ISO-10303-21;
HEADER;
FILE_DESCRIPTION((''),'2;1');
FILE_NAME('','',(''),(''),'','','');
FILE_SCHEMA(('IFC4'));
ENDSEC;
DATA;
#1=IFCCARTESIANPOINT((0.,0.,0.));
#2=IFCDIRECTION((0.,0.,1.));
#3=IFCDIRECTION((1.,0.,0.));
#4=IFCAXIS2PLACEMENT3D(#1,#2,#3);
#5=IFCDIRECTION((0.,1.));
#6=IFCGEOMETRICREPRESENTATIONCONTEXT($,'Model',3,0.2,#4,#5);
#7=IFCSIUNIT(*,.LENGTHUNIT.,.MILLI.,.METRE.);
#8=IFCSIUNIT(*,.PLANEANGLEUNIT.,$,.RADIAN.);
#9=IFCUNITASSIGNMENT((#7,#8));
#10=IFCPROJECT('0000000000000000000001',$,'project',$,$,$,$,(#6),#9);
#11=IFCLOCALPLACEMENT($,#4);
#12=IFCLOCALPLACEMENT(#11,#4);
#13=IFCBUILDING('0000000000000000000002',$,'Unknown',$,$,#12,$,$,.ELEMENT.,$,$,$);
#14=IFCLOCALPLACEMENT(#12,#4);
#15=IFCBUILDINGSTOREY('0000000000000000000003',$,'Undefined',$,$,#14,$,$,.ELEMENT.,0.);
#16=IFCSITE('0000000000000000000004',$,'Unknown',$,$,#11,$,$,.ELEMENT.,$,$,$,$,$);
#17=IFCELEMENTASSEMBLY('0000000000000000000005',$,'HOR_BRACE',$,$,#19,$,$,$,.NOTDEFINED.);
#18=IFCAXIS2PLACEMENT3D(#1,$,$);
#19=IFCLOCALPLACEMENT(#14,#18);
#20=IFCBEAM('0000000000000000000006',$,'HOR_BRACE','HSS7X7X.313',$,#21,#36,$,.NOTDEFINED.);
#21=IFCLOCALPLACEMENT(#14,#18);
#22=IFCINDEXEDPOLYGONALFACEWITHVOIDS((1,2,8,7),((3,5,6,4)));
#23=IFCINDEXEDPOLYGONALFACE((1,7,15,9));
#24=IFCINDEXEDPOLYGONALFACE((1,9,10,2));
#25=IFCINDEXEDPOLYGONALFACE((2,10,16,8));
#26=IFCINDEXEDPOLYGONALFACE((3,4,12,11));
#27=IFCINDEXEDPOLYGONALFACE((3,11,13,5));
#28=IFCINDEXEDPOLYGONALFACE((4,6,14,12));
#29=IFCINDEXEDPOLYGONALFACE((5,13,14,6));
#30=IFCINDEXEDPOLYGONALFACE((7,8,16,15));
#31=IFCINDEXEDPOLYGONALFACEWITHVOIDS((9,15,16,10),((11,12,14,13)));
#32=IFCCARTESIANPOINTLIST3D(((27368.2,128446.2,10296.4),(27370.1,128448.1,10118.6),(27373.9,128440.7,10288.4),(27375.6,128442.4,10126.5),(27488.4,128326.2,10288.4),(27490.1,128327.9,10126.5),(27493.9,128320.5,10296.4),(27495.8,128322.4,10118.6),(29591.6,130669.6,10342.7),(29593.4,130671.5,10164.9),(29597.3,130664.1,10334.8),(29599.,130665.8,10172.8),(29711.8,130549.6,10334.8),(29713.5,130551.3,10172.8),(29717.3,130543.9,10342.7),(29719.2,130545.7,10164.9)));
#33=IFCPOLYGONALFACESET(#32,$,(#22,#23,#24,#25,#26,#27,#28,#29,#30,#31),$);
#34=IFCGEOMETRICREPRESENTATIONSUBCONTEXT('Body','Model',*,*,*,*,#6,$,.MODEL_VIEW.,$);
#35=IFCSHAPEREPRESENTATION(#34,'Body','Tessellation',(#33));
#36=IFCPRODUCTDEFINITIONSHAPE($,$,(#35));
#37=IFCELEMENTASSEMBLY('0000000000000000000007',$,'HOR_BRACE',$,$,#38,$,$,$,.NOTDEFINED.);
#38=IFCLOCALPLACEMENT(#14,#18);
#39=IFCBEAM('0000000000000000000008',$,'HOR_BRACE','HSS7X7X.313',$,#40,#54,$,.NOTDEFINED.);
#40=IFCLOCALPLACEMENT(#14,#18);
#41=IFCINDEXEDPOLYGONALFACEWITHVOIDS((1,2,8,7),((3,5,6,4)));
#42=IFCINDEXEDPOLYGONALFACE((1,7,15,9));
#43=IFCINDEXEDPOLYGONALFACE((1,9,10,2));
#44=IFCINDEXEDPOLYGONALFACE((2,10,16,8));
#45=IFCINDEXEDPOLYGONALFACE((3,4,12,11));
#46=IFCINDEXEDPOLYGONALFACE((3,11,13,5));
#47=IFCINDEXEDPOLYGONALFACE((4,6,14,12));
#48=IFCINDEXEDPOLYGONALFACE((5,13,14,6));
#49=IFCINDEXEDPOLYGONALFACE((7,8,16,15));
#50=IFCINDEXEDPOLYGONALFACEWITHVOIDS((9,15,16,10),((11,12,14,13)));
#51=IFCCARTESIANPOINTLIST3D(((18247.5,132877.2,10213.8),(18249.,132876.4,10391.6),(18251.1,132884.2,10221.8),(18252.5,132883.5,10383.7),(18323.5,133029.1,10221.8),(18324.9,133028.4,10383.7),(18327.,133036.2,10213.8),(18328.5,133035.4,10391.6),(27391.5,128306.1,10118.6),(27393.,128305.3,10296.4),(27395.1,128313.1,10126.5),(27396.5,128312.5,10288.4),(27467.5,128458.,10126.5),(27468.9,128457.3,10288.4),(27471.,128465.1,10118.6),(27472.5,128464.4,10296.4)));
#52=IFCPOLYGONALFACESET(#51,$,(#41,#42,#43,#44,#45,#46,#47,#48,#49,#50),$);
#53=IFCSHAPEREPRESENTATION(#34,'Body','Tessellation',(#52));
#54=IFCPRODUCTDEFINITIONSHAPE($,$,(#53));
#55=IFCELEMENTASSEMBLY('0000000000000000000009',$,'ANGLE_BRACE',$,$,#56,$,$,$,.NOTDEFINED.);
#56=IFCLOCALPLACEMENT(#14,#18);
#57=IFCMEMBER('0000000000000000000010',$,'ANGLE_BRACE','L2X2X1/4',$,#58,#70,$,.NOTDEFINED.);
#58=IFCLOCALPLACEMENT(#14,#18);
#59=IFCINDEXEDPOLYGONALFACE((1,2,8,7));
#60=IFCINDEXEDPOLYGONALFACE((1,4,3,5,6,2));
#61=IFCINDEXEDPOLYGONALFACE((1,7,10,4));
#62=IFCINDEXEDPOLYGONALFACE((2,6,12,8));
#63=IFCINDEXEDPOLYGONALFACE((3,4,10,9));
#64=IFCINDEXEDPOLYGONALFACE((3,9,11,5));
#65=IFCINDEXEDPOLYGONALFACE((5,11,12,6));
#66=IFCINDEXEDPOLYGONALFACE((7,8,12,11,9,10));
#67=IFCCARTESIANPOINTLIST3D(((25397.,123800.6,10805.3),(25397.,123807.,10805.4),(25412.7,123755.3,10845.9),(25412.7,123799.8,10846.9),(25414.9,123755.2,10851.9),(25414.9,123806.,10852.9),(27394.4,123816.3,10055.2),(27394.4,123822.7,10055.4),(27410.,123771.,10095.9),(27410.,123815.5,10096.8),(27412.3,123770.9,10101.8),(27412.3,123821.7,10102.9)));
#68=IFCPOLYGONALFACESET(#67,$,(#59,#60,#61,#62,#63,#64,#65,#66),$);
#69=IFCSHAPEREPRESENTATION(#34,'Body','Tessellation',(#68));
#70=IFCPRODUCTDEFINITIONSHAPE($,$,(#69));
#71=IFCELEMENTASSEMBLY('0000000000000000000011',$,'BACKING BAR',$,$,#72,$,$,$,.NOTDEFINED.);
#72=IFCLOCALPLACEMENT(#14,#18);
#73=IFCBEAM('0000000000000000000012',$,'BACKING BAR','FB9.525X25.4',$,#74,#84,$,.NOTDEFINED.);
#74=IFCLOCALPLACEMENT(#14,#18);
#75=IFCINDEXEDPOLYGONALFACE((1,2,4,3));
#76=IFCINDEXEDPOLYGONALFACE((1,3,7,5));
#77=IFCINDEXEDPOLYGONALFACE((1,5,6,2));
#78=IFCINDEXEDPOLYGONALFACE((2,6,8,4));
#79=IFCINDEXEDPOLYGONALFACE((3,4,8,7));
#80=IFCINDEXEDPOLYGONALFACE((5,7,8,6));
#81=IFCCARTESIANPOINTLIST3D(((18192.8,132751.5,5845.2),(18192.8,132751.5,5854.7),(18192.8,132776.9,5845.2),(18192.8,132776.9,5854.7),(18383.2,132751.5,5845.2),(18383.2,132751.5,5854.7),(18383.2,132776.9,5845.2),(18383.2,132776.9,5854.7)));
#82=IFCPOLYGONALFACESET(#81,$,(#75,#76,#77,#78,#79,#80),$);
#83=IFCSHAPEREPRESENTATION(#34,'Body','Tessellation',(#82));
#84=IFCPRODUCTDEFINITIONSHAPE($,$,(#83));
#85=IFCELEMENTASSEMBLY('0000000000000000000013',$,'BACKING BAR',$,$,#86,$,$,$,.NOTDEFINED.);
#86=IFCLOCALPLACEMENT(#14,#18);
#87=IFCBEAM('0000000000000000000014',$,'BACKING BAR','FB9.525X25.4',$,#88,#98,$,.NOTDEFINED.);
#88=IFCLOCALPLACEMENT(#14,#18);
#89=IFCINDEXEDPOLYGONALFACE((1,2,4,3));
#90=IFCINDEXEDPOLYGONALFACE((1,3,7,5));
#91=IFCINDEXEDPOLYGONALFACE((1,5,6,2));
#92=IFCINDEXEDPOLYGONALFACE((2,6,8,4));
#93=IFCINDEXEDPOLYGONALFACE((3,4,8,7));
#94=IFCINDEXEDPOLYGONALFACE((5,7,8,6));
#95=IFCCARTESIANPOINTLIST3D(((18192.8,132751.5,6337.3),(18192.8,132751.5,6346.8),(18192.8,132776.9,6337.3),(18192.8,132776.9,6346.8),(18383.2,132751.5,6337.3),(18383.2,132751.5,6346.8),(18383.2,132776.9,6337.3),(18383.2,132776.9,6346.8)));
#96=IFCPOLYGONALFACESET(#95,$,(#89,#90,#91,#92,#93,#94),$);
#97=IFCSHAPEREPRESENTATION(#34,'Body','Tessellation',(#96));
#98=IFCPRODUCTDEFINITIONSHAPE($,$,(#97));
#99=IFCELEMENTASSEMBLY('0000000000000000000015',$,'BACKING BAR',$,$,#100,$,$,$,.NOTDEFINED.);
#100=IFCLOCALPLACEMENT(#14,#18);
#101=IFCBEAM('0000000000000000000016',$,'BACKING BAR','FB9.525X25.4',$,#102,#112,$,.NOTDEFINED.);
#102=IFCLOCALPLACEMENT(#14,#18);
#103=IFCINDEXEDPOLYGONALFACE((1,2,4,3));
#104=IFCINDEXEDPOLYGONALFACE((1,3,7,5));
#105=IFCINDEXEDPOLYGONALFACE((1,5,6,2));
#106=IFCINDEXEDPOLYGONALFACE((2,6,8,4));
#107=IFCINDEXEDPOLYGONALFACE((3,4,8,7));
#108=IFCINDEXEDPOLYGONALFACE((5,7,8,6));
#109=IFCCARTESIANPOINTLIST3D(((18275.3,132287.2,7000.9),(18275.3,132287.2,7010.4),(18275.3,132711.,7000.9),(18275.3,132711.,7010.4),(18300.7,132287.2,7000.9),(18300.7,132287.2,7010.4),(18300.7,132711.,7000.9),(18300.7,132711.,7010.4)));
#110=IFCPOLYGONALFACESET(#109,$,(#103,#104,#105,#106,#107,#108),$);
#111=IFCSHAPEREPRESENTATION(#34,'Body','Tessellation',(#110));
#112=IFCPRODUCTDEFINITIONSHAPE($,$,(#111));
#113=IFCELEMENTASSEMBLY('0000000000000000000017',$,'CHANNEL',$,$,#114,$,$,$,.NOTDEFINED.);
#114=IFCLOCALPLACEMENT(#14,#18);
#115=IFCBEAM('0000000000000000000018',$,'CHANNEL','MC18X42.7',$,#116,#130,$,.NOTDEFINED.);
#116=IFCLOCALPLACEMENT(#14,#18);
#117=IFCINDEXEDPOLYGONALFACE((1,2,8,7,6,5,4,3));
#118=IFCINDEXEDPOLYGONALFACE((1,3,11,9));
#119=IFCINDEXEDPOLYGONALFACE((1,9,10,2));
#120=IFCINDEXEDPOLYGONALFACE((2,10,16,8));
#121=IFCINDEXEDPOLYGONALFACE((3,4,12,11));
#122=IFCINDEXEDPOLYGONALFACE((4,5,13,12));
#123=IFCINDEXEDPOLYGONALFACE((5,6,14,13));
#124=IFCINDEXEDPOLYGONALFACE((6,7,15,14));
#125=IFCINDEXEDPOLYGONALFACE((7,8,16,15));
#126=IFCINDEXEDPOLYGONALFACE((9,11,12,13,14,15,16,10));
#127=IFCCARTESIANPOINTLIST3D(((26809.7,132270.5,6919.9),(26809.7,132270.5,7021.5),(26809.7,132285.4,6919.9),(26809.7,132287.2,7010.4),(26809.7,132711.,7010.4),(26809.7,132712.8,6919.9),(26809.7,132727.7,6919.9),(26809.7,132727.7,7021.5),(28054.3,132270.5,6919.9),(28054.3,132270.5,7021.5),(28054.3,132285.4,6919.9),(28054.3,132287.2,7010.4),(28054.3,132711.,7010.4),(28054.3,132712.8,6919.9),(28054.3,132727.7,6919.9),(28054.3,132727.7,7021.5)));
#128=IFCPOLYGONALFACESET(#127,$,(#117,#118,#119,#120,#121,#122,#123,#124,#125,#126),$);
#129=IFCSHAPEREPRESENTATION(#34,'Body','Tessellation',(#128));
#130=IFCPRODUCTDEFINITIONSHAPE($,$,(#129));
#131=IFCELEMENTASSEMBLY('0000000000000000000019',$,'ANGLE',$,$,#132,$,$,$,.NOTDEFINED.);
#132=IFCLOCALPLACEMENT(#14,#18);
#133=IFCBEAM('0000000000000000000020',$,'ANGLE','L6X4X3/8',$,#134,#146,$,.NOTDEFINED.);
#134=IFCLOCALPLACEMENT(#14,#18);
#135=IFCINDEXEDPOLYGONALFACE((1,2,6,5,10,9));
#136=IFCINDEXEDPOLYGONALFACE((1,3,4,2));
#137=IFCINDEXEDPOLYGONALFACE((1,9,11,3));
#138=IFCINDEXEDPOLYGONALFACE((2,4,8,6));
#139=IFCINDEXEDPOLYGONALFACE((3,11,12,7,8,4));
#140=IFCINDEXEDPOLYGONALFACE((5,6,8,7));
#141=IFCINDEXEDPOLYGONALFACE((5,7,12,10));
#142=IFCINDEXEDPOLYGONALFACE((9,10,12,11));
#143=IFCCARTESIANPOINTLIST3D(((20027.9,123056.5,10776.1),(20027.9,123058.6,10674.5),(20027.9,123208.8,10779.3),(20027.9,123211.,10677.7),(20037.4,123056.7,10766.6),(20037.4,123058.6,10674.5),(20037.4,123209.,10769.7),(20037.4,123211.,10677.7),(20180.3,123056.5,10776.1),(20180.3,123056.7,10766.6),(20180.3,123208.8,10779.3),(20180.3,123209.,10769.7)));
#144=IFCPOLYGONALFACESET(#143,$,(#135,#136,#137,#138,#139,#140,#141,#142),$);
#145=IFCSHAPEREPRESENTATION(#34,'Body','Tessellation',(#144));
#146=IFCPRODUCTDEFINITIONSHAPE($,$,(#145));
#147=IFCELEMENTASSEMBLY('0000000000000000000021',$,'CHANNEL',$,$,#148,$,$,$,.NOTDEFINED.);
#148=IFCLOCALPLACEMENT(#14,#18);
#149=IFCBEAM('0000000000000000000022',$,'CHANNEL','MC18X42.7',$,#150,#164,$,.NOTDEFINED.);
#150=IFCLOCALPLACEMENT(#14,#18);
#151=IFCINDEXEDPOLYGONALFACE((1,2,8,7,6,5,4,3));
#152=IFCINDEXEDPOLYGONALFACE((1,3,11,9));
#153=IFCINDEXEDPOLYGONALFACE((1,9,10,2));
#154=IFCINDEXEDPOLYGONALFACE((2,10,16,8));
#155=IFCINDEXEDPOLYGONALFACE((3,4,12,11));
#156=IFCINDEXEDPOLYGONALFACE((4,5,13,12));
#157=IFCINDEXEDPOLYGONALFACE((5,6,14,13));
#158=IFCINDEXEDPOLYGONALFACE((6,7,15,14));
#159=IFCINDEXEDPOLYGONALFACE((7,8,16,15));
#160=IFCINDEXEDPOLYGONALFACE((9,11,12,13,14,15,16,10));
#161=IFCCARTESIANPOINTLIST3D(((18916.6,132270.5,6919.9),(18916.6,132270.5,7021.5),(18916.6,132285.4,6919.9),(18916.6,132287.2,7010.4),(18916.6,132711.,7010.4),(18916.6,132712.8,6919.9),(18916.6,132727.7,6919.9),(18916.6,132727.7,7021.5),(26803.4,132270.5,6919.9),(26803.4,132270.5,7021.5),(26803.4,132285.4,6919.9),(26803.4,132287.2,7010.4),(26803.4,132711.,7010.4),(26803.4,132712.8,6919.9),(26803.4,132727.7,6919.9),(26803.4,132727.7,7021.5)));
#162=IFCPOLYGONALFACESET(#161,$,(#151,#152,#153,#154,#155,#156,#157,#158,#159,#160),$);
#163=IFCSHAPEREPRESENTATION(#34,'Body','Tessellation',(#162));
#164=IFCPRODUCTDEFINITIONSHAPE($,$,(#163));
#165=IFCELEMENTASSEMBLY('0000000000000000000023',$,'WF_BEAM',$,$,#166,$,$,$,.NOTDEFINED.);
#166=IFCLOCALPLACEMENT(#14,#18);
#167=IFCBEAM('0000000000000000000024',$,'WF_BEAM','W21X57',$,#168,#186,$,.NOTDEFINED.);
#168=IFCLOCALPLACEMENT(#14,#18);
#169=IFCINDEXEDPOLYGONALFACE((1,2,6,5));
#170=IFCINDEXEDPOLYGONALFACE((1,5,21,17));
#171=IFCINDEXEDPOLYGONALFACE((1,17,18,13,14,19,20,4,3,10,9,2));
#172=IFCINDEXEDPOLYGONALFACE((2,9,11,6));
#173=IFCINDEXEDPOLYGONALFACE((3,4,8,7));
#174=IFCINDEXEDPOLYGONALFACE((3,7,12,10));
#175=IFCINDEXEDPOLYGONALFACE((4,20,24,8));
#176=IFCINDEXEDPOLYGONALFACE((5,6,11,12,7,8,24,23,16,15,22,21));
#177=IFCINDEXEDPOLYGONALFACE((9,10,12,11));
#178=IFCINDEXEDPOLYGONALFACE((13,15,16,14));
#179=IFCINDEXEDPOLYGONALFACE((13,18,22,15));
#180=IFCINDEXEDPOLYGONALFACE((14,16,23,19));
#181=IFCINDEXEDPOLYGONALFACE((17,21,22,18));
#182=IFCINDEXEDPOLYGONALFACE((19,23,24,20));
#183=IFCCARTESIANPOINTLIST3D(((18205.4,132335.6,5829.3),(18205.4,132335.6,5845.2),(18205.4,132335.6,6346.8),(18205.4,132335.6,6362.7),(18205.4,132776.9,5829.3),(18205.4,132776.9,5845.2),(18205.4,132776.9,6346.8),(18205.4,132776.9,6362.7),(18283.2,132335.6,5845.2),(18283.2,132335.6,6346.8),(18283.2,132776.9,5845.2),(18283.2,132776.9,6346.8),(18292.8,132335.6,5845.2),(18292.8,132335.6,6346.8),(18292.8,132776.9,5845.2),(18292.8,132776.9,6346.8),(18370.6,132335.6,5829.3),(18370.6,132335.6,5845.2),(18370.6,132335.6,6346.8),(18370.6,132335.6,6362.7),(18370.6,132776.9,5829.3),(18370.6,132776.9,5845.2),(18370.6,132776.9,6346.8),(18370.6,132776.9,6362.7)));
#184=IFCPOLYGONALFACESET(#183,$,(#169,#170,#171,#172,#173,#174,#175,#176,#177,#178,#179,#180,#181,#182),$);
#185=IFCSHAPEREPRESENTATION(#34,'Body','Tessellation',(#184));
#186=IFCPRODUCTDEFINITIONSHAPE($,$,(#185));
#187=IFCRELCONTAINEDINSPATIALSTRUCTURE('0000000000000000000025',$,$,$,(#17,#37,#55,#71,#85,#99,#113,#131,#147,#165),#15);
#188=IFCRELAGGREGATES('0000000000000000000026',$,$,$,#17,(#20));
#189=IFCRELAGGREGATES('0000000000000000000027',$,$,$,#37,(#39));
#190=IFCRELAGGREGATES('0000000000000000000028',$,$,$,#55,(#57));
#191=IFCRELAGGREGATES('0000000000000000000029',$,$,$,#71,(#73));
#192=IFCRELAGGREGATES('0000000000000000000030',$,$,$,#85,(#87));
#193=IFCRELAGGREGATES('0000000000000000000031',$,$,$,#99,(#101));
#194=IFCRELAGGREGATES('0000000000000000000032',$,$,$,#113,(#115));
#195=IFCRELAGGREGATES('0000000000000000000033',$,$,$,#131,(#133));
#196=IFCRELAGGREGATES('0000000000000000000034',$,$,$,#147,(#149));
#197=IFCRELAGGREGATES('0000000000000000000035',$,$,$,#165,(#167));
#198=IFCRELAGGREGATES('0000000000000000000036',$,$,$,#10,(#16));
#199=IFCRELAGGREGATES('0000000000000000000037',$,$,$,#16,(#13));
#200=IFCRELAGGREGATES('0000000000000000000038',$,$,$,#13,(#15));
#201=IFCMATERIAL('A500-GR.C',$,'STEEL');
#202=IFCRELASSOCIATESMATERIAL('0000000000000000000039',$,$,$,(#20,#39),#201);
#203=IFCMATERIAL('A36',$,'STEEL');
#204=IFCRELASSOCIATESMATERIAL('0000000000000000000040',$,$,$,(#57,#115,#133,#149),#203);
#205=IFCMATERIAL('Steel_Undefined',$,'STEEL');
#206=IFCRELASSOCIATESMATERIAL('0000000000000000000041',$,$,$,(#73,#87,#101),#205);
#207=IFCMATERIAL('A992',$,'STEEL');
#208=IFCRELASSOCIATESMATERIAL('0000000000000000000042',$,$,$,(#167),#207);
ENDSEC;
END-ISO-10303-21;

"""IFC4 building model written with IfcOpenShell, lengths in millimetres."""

from ifc_helpers import new_model, si_unit, direction, frame, origin_with_axes, place, context, subcontext, project, spatial, line, indexed_curve, outline, extrude, material, element, aggregate, save


model = new_model("IFC4")

# Units and contexts
model_context = context("Model", 3, precision=0.2, world=origin_with_axes(), true_north=direction((0.0, 1.0)))
body_context = subcontext(model_context, "Body", "Model", "MODEL_VIEW")
ifc_project = project(units=[si_unit("LENGTHUNIT", "METRE", prefix="MILLI"), si_unit("PLANEANGLEUNIT", "RADIAN")], contexts=[model_context])

# Site, building, storey
site_placement = place(None, origin_with_axes())
site = spatial("IfcSite", under=ifc_project, at=site_placement, Name="Unknown", CompositionType="ELEMENT")
building_placement = place(site_placement, origin_with_axes())
building = spatial("IfcBuilding", under=site, at=building_placement, Name="Unknown", CompositionType="ELEMENT")
storey_placement = place(building_placement, origin_with_axes())
storey = spatial("IfcBuildingStorey", under=building, at=storey_placement, Name="Undefined", CompositionType="ELEMENT", Elevation=0.0)

# Shared definitions
ifc_material_1 = material(Name="A992", Category="STEEL")
ifc_material_2 = material(Name="A500-GR.C", Category="STEEL")

# Element assemblies, beams
assembly_1_placement = place(storey_placement, frame((27432.0, 128384.3, 10207.5), z_axis=(0.707107, -0.707107, 0.0), x_axis=(0.70703, 0.70703, 0.01473)))
assembly_1 = element("IfcElementAssembly", 1, at=assembly_1_placement, inside=storey, Name="HOR_BRACE", PredefinedType="NOTDEFINED")
beam_1_placement = place(assembly_1_placement, origin_with_axes())
beam_1 = element("IfcBeam", 2, at=beam_1_placement, material=ifc_material_2, Name="HOR_BRACE", Description="HSS7X7X.313", PredefinedType="NOTDEFINED", context=body_context, shape_type="SolidModel", body=[
    extrude(outline(indexed_curve([(-88.9, -88.9), (88.9, -88.9), (88.9, 88.9), (-88.9, 88.9)], segments=[line(1, 2, 3, 4, 1)]), holes=[indexed_curve([(-81.0, -81.0), (-81.0, 81.0), (81.0, 81.0), (81.0, -81.0)], segments=[line(1, 2, 3, 4, 1)])]), frame((0.0, 0.0, 0.0), z_axis=(-1.0, 0.0, 0.0), x_axis=(0.0, 0.0, 1.0)), (0.0, 0.0, -1.0), 3144.7),
])
aggregate(assembly_1, [beam_1])
assembly_2_placement = place(storey_placement, frame((27432.0, 128385.2, 10207.5), z_axis=(0.447141, 0.894463, 0.0), x_axis=(-0.894425, 0.447122, 0.009317)))
assembly_2 = element("IfcElementAssembly", 3, at=assembly_2_placement, inside=storey, Name="HOR_BRACE", PredefinedType="NOTDEFINED")
beam_2_placement = place(assembly_2_placement, origin_with_axes())
beam_2 = element("IfcBeam", 4, at=beam_2_placement, material=ifc_material_2, Name="HOR_BRACE", Description="HSS7X7X.313", PredefinedType="NOTDEFINED", context=body_context, shape_type="SolidModel", body=[
    extrude(outline(indexed_curve([(-88.9, -88.9), (88.9, -88.9), (88.9, 88.9), (-88.9, 88.9)], segments=[line(1, 2, 3, 4, 1)]), holes=[indexed_curve([(-81.0, -81.0), (-81.0, 81.0), (81.0, 81.0), (81.0, -81.0)], segments=[line(1, 2, 3, 4, 1)])]), frame((0.0, 0.0, 0.0), z_axis=(-1.0, 0.0, 0.0), x_axis=(0.0, 0.0, 1.0)), (0.0, 0.0, -1.0), 10223.3),
])
aggregate(assembly_2, [beam_2])

# Element assembly, member
assembly_3_placement = place(storey_placement, frame((27403.3, 123796.8, 10078.6), z_axis=(0.000032, -0.999783, -0.020841), x_axis=(-0.936143, -0.007358, 0.351542)))
assembly_3 = element("IfcElementAssembly", 5, at=assembly_3_placement, inside=storey, Name="ANGLE_BRACE", PredefinedType="NOTDEFINED")
ifc_material_3 = material(Name="A36", Category="STEEL")
member_1_placement = place(assembly_3_placement, origin_with_axes())
member_1 = element("IfcMember", 6, at=member_1_placement, material=ifc_material_3, Name="ANGLE_BRACE", Description="L2X2X1/4", PredefinedType="NOTDEFINED", context=body_context, shape_type="SolidModel", body=[
    extrude(outline(indexed_curve([(-25.4, -25.4), (25.4, -25.4), (25.4, -19.1), (-19.1, -19.1), (-19.1, 25.4), (-25.4, 25.4)], segments=[line(1, 2, 3, 4, 5, 6, 1)])), frame((0.0, 0.0, 0.0), z_axis=(-1.0, 0.0, 0.0), x_axis=(0.0, 0.0, 1.0)), (0.0, 0.0, -1.0), 2133.6),
])
aggregate(assembly_3, [member_1])

# Element assemblies, beams
assembly_4_placement = place(storey_placement, frame((18383.2, 132764.2, 5849.9), z_axis=(0.0, 0.0, 1.0), x_axis=(-1.0, 0.0, 0.0)))
assembly_4 = element("IfcElementAssembly", 7, at=assembly_4_placement, inside=storey, Name="BACKING BAR", PredefinedType="NOTDEFINED")
ifc_material_4 = material(Name="Steel_Undefined", Category="STEEL")
beam_3_placement = place(assembly_4_placement, origin_with_axes())
beam_3 = element("IfcBeam", 8, at=beam_3_placement, material=ifc_material_4, Name="BACKING BAR", Description="FB9.525X25.4", PredefinedType="NOTDEFINED", context=body_context, shape_type="SolidModel", body=[
    extrude(outline(indexed_curve([(-4.8, -12.7), (4.8, -12.7), (4.8, 12.7), (-4.8, 12.7)], segments=[line(1, 2, 3, 4, 1)])), frame((0.0, 0.0, 0.0), z_axis=(-1.0, 0.0, 0.0), x_axis=(0.0, 0.0, 1.0)), (0.0, 0.0, -1.0), 190.5),
])
aggregate(assembly_4, [beam_3])
assembly_5_placement = place(storey_placement, frame((18383.2, 132764.2, 6342.1), z_axis=(0.0, 0.0, 1.0), x_axis=(-1.0, 0.0, 0.0)))
assembly_5 = element("IfcElementAssembly", 9, at=assembly_5_placement, inside=storey, Name="BACKING BAR", PredefinedType="NOTDEFINED")
beam_4_placement = place(assembly_5_placement, origin_with_axes())
beam_4 = element("IfcBeam", 10, at=beam_4_placement, material=ifc_material_4, Name="BACKING BAR", Description="FB9.525X25.4", PredefinedType="NOTDEFINED", context=body_context, shape_type="SolidModel", body=[
    extrude(outline(indexed_curve([(-4.8, -12.7), (4.8, -12.7), (4.8, 12.7), (-4.8, 12.7)], segments=[line(1, 2, 3, 4, 1)])), frame((0.0, 0.0, 0.0), z_axis=(-1.0, 0.0, 0.0), x_axis=(0.0, 0.0, 1.0)), (0.0, 0.0, -1.0), 190.5),
])
aggregate(assembly_5, [beam_4])
assembly_6_placement = place(storey_placement, frame((18288.0, 132711.0, 7005.6), z_axis=(0.0, 0.0, 1.0), x_axis=(0.0, -1.0, 0.0)))
assembly_6 = element("IfcElementAssembly", 11, at=assembly_6_placement, inside=storey, Name="BACKING BAR", PredefinedType="NOTDEFINED")
beam_5_placement = place(assembly_6_placement, origin_with_axes())
beam_5 = element("IfcBeam", 12, at=beam_5_placement, material=ifc_material_4, Name="BACKING BAR", Description="FB9.525X25.4", PredefinedType="NOTDEFINED", context=body_context, shape_type="SolidModel", body=[
    extrude(outline(indexed_curve([(-4.8, -12.7), (4.8, -12.7), (4.8, 12.7), (-4.8, 12.7)], segments=[line(1, 2, 3, 4, 1)])), frame((0.0, 0.0, 0.0), z_axis=(-1.0, 0.0, 0.0), x_axis=(0.0, 0.0, 1.0)), (0.0, 0.0, -1.0), 423.9),
])
aggregate(assembly_6, [beam_5])
assembly_7_placement = place(storey_placement, frame((26809.7, 132499.1, 6970.7), z_axis=(0.0, 0.0, -1.0), x_axis=(1.0, 0.0, 0.0)))
assembly_7 = element("IfcElementAssembly", 13, at=assembly_7_placement, inside=storey, Name="CHANNEL", PredefinedType="NOTDEFINED")
beam_6_placement = place(assembly_7_placement, origin_with_axes())
beam_6 = element("IfcBeam", 14, at=beam_6_placement, material=ifc_material_3, Name="CHANNEL", Description="MC18X42.7", PredefinedType="NOTDEFINED", context=body_context, shape_type="SolidModel", body=[
    extrude(outline(indexed_curve([(-50.8, -228.6), (50.8, -228.6), (50.8, -213.7), (-39.7, -211.9), (-39.7, 211.9), (50.8, 213.7), (50.8, 228.6), (-50.8, 228.6)], segments=[line(1, 2, 3, 4, 5, 6, 7, 8, 1)])), frame((0.0, 0.0, 0.0), z_axis=(-1.0, 0.0, 0.0), x_axis=(0.0, 0.0, 1.0)), (0.0, 0.0, -1.0), 1244.6),
])
aggregate(assembly_7, [beam_6])
assembly_8_placement = place(storey_placement, frame((20104.1, 123057.5, 10725.3), z_axis=(0.0, 0.020829, -0.999783), x_axis=(0.0, 0.999783, 0.020819)))
assembly_8 = element("IfcElementAssembly", 15, at=assembly_8_placement, inside=storey, Name="ANGLE", PredefinedType="NOTDEFINED")
beam_7_placement = place(assembly_8_placement, origin_with_axes())
beam_7 = element("IfcBeam", 16, at=beam_7_placement, material=ifc_material_3, Name="ANGLE", Description="L6X4X3/8", PredefinedType="NOTDEFINED", context=body_context, shape_type="SolidModel", body=[
    extrude(outline(indexed_curve([(-50.8, -76.2), (50.8, -76.2), (50.8, -66.7), (-41.3, -66.7), (-41.3, 76.2), (-50.8, 76.2)], segments=[line(1, 2, 3, 4, 5, 6, 1)])), frame((0.0, 0.0, 0.0), z_axis=(-1.0, 0.0, 0.0), x_axis=(0.0, 0.0, 1.0)), (0.0, 0.0, -1.0), 152.4),
])
aggregate(assembly_8, [beam_7])
assembly_9_placement = place(storey_placement, frame((26803.3, 132499.1, 6970.7), z_axis=(0.0, 0.0, -1.0), x_axis=(-1.0, 0.0, 0.0)))
assembly_9 = element("IfcElementAssembly", 17, at=assembly_9_placement, inside=storey, Name="CHANNEL", PredefinedType="NOTDEFINED")
beam_8_placement = place(assembly_9_placement, origin_with_axes())
beam_8 = element("IfcBeam", 18, at=beam_8_placement, material=ifc_material_3, Name="CHANNEL", Description="MC18X42.7", PredefinedType="NOTDEFINED", context=body_context, shape_type="SolidModel", body=[
    extrude(outline(indexed_curve([(-50.8, -228.6), (50.8, -228.6), (50.8, -213.7), (-39.7, -211.9), (-39.7, 211.9), (50.8, 213.7), (50.8, 228.6), (-50.8, 228.6)], segments=[line(1, 2, 3, 4, 5, 6, 7, 8, 1)])), frame((0.0, 0.0, 0.0), z_axis=(-1.0, 0.0, 0.0), x_axis=(0.0, 0.0, 1.0)), (0.0, 0.0, -1.0), 7886.7),
])
aggregate(assembly_9, [beam_8])
assembly_10_placement = place(storey_placement, frame((18288.0, 132335.6, 6096.0), z_axis=(1.0, 0.0, 0.0), x_axis=(0.0, 1.0, 0.0)))
assembly_10 = element("IfcElementAssembly", 19, at=assembly_10_placement, inside=storey, Name="WF_BEAM", PredefinedType="NOTDEFINED")
beam_9_placement = place(assembly_10_placement, origin_with_axes())
beam_9 = element("IfcBeam", 20, at=beam_9_placement, material=ifc_material_1, Name="WF_BEAM", Description="W21X57", PredefinedType="NOTDEFINED", context=body_context, shape_type="SolidModel", body=[
    extrude(outline(indexed_curve([(-82.5, -266.7), (82.5, -266.7), (82.5, -250.8), (4.8, -250.8), (4.8, 250.8), (82.5, 250.8), (82.5, 266.7), (-82.5, 266.7), (-82.5, 250.8), (-4.8, 250.8), (-4.8, -250.8), (-82.5, -250.8)], segments=[line(1, 2, 3, 4, 5, 6, 7, 8, 9, 10, 11, 12, 1)])), frame((0.0, 0.0, 0.0), z_axis=(-1.0, 0.0, 0.0), x_axis=(0.0, 0.0, 1.0)), (0.0, 0.0, -1.0), 441.3),
])
aggregate(assembly_10, [beam_9])

save(model, "model.ifc")
